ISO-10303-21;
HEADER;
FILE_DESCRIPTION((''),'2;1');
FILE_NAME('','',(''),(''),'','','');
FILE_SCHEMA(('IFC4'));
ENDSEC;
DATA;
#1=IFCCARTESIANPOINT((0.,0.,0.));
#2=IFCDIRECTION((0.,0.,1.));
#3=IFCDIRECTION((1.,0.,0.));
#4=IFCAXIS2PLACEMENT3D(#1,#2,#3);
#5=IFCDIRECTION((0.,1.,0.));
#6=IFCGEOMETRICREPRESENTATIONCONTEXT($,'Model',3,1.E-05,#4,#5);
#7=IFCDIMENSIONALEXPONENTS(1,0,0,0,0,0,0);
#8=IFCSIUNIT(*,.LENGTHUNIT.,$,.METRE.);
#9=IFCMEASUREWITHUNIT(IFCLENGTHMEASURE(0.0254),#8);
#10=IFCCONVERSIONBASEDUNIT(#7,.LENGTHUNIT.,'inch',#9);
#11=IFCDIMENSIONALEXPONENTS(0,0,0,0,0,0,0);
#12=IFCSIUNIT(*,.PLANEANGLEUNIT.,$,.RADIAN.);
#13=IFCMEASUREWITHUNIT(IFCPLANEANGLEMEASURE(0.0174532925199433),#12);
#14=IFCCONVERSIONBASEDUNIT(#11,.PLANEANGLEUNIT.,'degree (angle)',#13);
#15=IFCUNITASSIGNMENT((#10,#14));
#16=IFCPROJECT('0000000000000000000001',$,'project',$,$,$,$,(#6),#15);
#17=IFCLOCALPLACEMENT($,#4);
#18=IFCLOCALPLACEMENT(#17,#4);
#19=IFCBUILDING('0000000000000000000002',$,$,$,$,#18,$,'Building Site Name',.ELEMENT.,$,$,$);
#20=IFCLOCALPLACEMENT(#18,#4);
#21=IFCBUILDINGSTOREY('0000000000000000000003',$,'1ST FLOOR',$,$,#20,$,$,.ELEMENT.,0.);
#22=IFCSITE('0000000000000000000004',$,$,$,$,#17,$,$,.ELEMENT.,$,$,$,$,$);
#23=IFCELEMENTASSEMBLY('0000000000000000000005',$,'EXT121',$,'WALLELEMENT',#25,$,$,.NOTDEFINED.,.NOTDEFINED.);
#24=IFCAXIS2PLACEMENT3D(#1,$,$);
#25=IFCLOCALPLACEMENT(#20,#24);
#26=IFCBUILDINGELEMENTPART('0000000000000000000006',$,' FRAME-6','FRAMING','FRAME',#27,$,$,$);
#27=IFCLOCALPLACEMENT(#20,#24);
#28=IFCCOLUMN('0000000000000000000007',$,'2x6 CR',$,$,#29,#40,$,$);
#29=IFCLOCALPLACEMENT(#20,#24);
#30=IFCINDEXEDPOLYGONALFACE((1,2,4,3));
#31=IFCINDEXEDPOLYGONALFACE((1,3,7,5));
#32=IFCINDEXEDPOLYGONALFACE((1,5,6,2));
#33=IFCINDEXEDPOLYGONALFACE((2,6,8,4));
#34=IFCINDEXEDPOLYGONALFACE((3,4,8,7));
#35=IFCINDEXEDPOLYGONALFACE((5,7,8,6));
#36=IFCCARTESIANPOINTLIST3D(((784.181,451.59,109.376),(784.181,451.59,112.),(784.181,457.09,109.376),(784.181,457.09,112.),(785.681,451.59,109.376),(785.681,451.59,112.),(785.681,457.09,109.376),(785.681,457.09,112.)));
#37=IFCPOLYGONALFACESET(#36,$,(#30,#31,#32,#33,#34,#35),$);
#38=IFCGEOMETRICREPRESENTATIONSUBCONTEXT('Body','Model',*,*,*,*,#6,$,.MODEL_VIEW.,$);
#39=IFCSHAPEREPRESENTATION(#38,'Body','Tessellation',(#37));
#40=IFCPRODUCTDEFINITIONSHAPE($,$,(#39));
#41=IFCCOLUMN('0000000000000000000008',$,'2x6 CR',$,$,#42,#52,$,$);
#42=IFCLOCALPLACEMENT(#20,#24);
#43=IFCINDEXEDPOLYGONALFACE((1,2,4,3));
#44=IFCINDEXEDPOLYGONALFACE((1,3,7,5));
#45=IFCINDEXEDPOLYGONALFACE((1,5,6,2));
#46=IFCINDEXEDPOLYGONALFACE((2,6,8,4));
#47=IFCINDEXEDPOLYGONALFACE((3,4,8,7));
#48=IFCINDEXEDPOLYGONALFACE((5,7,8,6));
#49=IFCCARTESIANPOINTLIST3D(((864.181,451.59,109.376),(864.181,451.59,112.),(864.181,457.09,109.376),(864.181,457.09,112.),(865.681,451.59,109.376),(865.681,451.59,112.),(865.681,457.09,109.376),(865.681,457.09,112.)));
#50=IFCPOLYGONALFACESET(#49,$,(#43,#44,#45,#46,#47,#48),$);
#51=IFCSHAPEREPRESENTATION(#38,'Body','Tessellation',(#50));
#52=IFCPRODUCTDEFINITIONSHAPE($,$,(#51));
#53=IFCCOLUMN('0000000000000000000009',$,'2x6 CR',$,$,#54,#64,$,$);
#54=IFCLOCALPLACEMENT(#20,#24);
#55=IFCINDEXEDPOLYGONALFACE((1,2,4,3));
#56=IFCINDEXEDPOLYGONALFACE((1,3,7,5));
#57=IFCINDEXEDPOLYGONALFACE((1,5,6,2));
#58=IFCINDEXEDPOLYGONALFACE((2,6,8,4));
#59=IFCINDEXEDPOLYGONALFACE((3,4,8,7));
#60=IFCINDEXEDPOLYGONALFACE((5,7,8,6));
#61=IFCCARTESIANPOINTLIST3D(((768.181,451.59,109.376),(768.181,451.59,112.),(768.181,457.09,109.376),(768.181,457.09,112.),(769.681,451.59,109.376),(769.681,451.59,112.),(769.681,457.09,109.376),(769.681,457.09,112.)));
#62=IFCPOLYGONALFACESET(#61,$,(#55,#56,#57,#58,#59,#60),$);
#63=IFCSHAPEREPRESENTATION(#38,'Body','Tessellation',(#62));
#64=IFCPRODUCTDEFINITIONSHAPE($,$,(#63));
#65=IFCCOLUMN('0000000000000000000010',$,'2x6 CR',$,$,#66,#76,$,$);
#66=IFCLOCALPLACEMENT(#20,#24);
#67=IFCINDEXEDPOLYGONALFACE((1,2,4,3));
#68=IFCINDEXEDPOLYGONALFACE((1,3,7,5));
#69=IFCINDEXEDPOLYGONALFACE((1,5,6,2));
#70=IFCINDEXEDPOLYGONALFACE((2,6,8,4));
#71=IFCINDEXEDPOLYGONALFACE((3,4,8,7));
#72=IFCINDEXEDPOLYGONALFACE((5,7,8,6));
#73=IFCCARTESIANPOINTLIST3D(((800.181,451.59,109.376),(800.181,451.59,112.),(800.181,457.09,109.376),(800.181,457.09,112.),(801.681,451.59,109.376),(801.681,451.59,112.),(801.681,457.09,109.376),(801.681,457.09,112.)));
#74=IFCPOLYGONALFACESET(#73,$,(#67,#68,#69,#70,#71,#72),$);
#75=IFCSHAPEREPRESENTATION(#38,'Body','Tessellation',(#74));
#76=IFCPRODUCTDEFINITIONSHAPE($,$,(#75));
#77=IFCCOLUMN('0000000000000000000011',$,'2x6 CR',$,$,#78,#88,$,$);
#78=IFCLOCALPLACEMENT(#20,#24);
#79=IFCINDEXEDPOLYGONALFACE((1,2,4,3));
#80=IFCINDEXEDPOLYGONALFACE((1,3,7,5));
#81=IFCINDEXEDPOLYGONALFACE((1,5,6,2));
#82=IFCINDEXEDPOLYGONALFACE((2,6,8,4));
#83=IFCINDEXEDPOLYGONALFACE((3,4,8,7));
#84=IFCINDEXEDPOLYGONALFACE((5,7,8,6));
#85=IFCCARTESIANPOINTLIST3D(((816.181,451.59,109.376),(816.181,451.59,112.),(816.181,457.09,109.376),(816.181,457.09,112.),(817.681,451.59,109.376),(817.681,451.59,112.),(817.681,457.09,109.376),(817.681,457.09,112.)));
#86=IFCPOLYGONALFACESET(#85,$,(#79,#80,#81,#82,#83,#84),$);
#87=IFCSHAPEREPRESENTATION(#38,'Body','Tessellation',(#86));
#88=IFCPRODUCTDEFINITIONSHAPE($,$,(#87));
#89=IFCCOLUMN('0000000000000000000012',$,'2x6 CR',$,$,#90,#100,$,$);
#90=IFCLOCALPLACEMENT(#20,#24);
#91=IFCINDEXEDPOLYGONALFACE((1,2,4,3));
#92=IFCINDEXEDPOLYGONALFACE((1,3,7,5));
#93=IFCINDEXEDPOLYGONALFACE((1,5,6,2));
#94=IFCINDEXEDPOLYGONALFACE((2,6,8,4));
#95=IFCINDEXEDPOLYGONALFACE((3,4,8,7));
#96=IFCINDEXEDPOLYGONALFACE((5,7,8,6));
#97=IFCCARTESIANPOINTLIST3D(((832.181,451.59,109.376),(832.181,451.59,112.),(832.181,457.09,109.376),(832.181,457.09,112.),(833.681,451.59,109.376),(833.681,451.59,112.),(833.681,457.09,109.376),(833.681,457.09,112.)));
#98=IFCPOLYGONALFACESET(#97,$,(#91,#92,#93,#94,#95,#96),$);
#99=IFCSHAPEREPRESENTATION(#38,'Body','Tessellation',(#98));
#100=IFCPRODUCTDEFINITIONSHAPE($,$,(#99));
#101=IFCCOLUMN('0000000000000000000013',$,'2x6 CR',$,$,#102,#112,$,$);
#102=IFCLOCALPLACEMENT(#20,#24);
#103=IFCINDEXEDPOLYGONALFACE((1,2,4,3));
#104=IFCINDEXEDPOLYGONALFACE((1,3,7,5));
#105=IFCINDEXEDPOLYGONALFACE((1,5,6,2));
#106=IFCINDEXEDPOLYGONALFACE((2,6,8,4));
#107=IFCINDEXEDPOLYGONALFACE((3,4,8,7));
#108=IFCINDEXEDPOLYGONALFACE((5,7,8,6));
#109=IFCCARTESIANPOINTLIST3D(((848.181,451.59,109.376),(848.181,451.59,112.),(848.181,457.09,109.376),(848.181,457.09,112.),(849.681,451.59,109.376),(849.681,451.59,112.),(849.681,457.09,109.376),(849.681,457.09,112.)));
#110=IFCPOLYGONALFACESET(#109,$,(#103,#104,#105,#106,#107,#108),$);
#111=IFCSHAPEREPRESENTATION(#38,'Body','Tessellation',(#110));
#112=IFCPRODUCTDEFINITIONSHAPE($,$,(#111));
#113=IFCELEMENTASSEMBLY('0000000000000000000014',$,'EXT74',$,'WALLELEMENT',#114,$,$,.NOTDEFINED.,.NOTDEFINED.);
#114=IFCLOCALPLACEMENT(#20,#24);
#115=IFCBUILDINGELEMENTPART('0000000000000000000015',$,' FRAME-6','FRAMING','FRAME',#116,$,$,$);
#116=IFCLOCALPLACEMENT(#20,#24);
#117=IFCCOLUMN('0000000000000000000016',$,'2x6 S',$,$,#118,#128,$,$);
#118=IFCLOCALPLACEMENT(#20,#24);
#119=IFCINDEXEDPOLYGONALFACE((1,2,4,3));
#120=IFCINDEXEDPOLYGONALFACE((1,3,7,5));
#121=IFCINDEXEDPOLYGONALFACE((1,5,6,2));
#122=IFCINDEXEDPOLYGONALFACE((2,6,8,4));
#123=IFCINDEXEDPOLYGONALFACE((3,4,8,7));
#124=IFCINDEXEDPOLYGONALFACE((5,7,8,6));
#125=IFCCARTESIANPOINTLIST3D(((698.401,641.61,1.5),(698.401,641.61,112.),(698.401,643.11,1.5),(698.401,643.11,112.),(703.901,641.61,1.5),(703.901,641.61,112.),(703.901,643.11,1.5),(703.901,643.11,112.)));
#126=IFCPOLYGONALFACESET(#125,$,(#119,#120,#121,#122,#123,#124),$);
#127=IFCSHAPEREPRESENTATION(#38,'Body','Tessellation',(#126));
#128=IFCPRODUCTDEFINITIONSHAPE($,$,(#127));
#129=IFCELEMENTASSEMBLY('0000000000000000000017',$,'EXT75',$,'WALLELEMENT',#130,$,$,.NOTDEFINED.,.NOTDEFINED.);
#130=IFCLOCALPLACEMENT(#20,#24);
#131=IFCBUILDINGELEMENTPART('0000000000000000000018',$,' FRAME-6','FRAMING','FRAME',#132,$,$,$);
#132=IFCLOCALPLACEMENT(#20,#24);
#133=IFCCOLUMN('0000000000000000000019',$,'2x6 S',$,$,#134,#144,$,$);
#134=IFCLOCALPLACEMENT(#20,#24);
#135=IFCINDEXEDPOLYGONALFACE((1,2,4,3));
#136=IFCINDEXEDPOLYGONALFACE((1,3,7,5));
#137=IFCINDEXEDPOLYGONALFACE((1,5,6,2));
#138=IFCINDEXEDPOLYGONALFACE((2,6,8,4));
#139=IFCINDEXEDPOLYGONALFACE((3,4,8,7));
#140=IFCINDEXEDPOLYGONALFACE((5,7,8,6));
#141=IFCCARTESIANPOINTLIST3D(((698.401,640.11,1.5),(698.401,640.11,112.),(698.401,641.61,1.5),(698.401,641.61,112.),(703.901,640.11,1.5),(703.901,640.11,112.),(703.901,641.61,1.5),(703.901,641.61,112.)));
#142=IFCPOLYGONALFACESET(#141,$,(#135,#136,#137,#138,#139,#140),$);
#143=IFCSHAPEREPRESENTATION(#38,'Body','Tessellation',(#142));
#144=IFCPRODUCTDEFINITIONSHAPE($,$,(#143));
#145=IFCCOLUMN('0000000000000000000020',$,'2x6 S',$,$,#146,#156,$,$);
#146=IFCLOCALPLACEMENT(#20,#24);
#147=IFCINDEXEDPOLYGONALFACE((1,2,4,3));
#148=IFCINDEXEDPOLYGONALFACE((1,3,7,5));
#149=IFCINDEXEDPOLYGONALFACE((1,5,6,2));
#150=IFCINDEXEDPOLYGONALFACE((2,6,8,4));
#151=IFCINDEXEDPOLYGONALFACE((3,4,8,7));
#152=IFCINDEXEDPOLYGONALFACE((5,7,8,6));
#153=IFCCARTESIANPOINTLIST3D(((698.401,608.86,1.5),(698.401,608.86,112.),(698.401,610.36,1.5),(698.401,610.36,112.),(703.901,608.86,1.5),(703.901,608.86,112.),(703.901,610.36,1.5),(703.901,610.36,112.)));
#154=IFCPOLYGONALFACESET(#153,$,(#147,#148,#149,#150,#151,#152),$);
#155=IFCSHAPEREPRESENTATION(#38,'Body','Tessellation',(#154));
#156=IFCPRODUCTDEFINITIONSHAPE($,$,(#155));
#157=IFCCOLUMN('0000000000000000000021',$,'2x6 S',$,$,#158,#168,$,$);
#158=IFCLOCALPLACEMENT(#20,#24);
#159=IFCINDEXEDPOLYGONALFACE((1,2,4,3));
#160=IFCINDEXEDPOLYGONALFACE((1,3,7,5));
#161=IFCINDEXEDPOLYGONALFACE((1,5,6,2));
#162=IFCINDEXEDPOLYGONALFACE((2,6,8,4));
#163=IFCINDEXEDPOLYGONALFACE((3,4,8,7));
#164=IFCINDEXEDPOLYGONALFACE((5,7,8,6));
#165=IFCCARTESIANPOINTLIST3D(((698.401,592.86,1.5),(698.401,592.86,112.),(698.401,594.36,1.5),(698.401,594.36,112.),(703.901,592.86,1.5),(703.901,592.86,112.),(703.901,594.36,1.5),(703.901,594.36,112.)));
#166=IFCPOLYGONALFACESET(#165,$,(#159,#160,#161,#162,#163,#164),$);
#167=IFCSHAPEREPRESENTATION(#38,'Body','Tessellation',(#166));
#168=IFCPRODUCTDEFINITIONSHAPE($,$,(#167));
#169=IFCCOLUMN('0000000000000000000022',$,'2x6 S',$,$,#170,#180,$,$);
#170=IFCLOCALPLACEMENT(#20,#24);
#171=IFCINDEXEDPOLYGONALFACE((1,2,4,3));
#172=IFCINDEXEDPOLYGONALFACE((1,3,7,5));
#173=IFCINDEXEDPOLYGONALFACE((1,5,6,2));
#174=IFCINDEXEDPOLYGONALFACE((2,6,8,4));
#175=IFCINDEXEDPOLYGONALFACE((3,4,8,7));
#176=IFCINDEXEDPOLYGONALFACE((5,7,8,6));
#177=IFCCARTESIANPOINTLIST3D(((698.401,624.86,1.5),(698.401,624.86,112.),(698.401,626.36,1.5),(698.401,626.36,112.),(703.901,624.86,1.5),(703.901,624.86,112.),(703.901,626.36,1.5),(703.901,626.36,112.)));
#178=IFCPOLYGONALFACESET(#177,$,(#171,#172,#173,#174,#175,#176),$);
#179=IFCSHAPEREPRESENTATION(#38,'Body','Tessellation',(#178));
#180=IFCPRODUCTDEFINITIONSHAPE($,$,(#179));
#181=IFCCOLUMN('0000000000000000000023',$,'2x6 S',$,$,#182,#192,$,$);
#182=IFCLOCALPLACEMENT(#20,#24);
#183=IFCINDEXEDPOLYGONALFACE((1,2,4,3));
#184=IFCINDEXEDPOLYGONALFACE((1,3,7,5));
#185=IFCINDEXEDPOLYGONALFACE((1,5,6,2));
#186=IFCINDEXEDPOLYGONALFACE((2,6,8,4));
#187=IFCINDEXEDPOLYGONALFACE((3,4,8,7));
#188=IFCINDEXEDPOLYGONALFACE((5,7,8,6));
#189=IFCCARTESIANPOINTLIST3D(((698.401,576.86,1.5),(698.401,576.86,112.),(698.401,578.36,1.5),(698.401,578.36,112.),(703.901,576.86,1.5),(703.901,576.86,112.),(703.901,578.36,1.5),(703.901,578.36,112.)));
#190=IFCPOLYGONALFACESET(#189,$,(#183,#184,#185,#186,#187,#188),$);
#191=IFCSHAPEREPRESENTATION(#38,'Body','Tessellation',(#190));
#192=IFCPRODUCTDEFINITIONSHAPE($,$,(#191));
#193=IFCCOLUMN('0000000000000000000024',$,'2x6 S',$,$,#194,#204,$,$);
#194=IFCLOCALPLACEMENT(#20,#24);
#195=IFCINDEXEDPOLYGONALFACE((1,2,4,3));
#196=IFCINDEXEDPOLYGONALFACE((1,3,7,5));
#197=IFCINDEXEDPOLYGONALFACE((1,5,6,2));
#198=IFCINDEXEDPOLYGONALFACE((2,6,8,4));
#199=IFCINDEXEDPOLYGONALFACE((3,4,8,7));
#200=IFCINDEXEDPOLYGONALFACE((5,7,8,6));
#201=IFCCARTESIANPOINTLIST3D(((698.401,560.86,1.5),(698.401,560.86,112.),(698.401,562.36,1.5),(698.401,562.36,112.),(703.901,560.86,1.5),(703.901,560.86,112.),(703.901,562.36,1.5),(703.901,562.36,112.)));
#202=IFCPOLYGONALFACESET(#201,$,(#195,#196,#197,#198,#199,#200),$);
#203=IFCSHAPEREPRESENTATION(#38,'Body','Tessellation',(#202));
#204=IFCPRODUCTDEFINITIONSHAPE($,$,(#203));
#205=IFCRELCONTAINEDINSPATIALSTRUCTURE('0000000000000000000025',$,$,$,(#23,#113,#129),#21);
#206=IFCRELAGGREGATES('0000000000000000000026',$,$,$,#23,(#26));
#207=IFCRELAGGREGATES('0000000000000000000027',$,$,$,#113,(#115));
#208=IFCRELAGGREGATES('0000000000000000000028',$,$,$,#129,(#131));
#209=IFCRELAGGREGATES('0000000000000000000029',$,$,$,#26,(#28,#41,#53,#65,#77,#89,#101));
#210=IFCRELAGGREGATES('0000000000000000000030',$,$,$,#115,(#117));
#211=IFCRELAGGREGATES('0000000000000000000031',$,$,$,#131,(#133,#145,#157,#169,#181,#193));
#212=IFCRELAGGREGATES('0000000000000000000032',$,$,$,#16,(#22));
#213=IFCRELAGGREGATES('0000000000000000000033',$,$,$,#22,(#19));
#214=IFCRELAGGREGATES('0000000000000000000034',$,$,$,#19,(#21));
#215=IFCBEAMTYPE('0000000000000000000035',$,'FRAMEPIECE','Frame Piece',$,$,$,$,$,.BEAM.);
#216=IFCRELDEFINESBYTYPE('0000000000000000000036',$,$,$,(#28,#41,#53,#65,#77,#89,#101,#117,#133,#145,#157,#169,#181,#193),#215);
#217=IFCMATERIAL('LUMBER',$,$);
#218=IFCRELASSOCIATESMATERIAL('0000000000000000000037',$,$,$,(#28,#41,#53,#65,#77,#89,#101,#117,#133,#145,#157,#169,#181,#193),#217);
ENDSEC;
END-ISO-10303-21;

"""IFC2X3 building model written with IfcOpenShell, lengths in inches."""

from ifc_helpers import new_model, entity, si_unit, converted_unit, direction, frame, frame_2d, origin_with_axes, place, context, subcontext, project, spatial, rectangle, extrude, material, type_object, element, aggregate, save


model = new_model("IFC2X3")

# Units and contexts
model_context = context("Model", 3, precision=1e-05, world=origin_with_axes(), true_north=direction((0.0, 1.0, 0.0)))
body_context = subcontext(model_context, "Body", "Model", "MODEL_VIEW")
ifc_project = project(units=[converted_unit("LENGTHUNIT", "inch", entity("IfcLengthMeasure", 0.0254), si_unit("LENGTHUNIT", "METRE"), dimensions=[1, 0, 0, 0, 0, 0, 0]), converted_unit("PLANEANGLEUNIT", "degree (angle)", entity("IfcPlaneAngleMeasure", 0.0174532925199433), si_unit("PLANEANGLEUNIT", "RADIAN"), dimensions=[0, 0, 0, 0, 0, 0, 0])], contexts=[model_context])

# Site, building, storey
site_placement = place(None, origin_with_axes())
site = spatial("IfcSite", under=ifc_project, at=site_placement, CompositionType="ELEMENT")
building_placement = place(site_placement, origin_with_axes())
building = spatial("IfcBuilding", under=site, at=building_placement, LongName="Building Site Name", CompositionType="ELEMENT")
storey_placement = place(building_placement, origin_with_axes())
storey = spatial("IfcBuildingStorey", under=building, at=storey_placement, Name="1ST FLOOR", CompositionType="ELEMENT", Elevation=0.0)

# Element assembly, building element part, columns
assembly_1_placement = place(storey_placement, origin_with_axes())
assembly_1 = element("IfcElementAssembly", 1, at=assembly_1_placement, inside=storey, Name="EXT121", ObjectType="WALLELEMENT", AssemblyPlace="NOTDEFINED", PredefinedType="NOTDEFINED")
building_element_part_1 = element("IfcBuildingElementPart", 2, Name=" FRAME-6", Description="FRAMING", ObjectType="FRAME")
aggregate(assembly_1, [building_element_part_1])
ifc_material_1 = material(Name="LUMBER")
beam_type = type_object("IfcBeamType", Name="FRAMEPIECE", Description="Frame Piece", PredefinedType="BEAM")
column_1_placement = place(assembly_1_placement, frame((784.931, 454.34, 112.0), z_axis=(0.0, 0.0, -1.0), x_axis=(-1.0, 0.0, 0.0)))
column_1 = element("IfcColumn", 3, at=column_1_placement, type_object=beam_type, material=ifc_material_1, Name="2x6 CR", context=body_context, shape_type="SweptSolid", body=[
    extrude(rectangle(XDim=1.5, YDim=5.5, at=frame_2d((0.0, 0.0), x_axis=(-1.0, 0.0))), origin_with_axes(), (0.0, 0.0, 1.0), 2.624),
])
column_2_placement = place(assembly_1_placement, frame((864.931, 454.34, 112.0), z_axis=(0.0, 0.0, -1.0), x_axis=(-1.0, 0.0, 0.0)))
column_2 = element("IfcColumn", 4, at=column_2_placement, type_object=beam_type, material=ifc_material_1, Name="2x6 CR", context=body_context, shape_type="SweptSolid", body=[
    extrude(rectangle(XDim=1.5, YDim=5.5, at=frame_2d((0.0, 0.0), x_axis=(-1.0, 0.0))), origin_with_axes(), (0.0, 0.0, 1.0), 2.624),
])
column_3_placement = place(assembly_1_placement, frame((768.931, 454.34, 112.0), z_axis=(0.0, 0.0, -1.0), x_axis=(-1.0, 0.0, 0.0)))
column_3 = element("IfcColumn", 5, at=column_3_placement, type_object=beam_type, material=ifc_material_1, Name="2x6 CR", context=body_context, shape_type="SweptSolid", body=[
    extrude(rectangle(XDim=1.5, YDim=5.5, at=frame_2d((0.0, 0.0), x_axis=(-1.0, 0.0))), origin_with_axes(), (0.0, 0.0, 1.0), 2.624),
])
column_4_placement = place(assembly_1_placement, frame((800.931, 454.34, 112.0), z_axis=(0.0, 0.0, -1.0), x_axis=(-1.0, 0.0, 0.0)))
column_4 = element("IfcColumn", 6, at=column_4_placement, type_object=beam_type, material=ifc_material_1, Name="2x6 CR", context=body_context, shape_type="SweptSolid", body=[
    extrude(rectangle(XDim=1.5, YDim=5.5, at=frame_2d((0.0, 0.0), x_axis=(-1.0, 0.0))), origin_with_axes(), (0.0, 0.0, 1.0), 2.624),
])
column_5_placement = place(assembly_1_placement, frame((816.931, 454.34, 112.0), z_axis=(0.0, 0.0, -1.0), x_axis=(-1.0, 0.0, 0.0)))
column_5 = element("IfcColumn", 7, at=column_5_placement, type_object=beam_type, material=ifc_material_1, Name="2x6 CR", context=body_context, shape_type="SweptSolid", body=[
    extrude(rectangle(XDim=1.5, YDim=5.5, at=frame_2d((0.0, 0.0), x_axis=(-1.0, 0.0))), origin_with_axes(), (0.0, 0.0, 1.0), 2.624),
])
column_6_placement = place(assembly_1_placement, frame((832.931, 454.34, 112.0), z_axis=(0.0, 0.0, -1.0), x_axis=(-1.0, 0.0, 0.0)))
column_6 = element("IfcColumn", 8, at=column_6_placement, type_object=beam_type, material=ifc_material_1, Name="2x6 CR", context=body_context, shape_type="SweptSolid", body=[
    extrude(rectangle(XDim=1.5, YDim=5.5, at=frame_2d((0.0, 0.0), x_axis=(-1.0, 0.0))), origin_with_axes(), (0.0, 0.0, 1.0), 2.624),
])
column_7_placement = place(assembly_1_placement, frame((848.931, 454.34, 112.0), z_axis=(0.0, 0.0, -1.0), x_axis=(-1.0, 0.0, 0.0)))
column_7 = element("IfcColumn", 9, at=column_7_placement, type_object=beam_type, material=ifc_material_1, Name="2x6 CR", context=body_context, shape_type="SweptSolid", body=[
    extrude(rectangle(XDim=1.5, YDim=5.5, at=frame_2d((0.0, 0.0), x_axis=(-1.0, 0.0))), origin_with_axes(), (0.0, 0.0, 1.0), 2.624),
])

# Element assembly, building element part, column
assembly_2_placement = place(storey_placement, origin_with_axes())
assembly_2 = element("IfcElementAssembly", 10, at=assembly_2_placement, inside=storey, Name="EXT74", ObjectType="WALLELEMENT", AssemblyPlace="NOTDEFINED", PredefinedType="NOTDEFINED")
building_element_part_2 = element("IfcBuildingElementPart", 11, Name=" FRAME-6", Description="FRAMING", ObjectType="FRAME")
aggregate(assembly_2, [building_element_part_2])
column_8_placement = place(assembly_2_placement, frame((701.151, 642.36, 1.5), z_axis=(0.0, 0.0, 1.0), x_axis=(0.0, 1.0, 0.0)))
column_8 = element("IfcColumn", 12, at=column_8_placement, type_object=beam_type, material=ifc_material_1, Name="2x6 S", context=body_context, shape_type="SweptSolid", body=[
    extrude(rectangle(XDim=1.5, YDim=5.5, at=frame_2d((0.0, 0.0), x_axis=(-1.0, 0.0))), frame((0.0, 0.0, 0.0), z_axis=(0.0, 0.0, 1.0), x_axis=(1.0, 0.0, 0.0)), (0.0, 0.0, 1.0), 110.5),
])

# Element assembly, building element part, columns
assembly_3_placement = place(storey_placement, origin_with_axes())
assembly_3 = element("IfcElementAssembly", 13, at=assembly_3_placement, inside=storey, Name="EXT75", ObjectType="WALLELEMENT", AssemblyPlace="NOTDEFINED", PredefinedType="NOTDEFINED")
building_element_part_3 = element("IfcBuildingElementPart", 14, Name=" FRAME-6", Description="FRAMING", ObjectType="FRAME")
aggregate(assembly_3, [building_element_part_3])
column_9_placement = place(assembly_3_placement, frame((701.151, 640.86, 112.0), z_axis=(0.0, 0.0, -1.0), x_axis=(0.0, -1.0, 0.0)))
column_9 = element("IfcColumn", 15, at=column_9_placement, type_object=beam_type, material=ifc_material_1, Name="2x6 S", context=body_context, shape_type="SweptSolid", body=[
    extrude(rectangle(XDim=1.5, YDim=5.5, at=frame_2d((0.0, 0.0), x_axis=(-1.0, 0.0))), origin_with_axes(), (0.0, 0.0, 1.0), 110.5),
])
column_10_placement = place(assembly_3_placement, frame((701.151, 609.61, 112.0), z_axis=(0.0, 0.0, -1.0), x_axis=(0.0, -1.0, 0.0)))
column_10 = element("IfcColumn", 16, at=column_10_placement, type_object=beam_type, material=ifc_material_1, Name="2x6 S", context=body_context, shape_type="SweptSolid", body=[
    extrude(rectangle(XDim=1.5, YDim=5.5, at=frame_2d((0.0, 0.0), x_axis=(-1.0, 0.0))), origin_with_axes(), (0.0, 0.0, 1.0), 110.5),
])
column_11_placement = place(assembly_3_placement, frame((701.151, 593.61, 112.0), z_axis=(0.0, 0.0, -1.0), x_axis=(0.0, -1.0, 0.0)))
column_11 = element("IfcColumn", 17, at=column_11_placement, type_object=beam_type, material=ifc_material_1, Name="2x6 S", context=body_context, shape_type="SweptSolid", body=[
    extrude(rectangle(XDim=1.5, YDim=5.5, at=frame_2d((0.0, 0.0), x_axis=(-1.0, 0.0))), origin_with_axes(), (0.0, 0.0, 1.0), 110.5),
])
column_12_placement = place(assembly_3_placement, frame((701.151, 625.61, 112.0), z_axis=(0.0, 0.0, -1.0), x_axis=(0.0, -1.0, 0.0)))
column_12 = element("IfcColumn", 18, at=column_12_placement, type_object=beam_type, material=ifc_material_1, Name="2x6 S", context=body_context, shape_type="SweptSolid", body=[
    extrude(rectangle(XDim=1.5, YDim=5.5, at=frame_2d((0.0, 0.0), x_axis=(-1.0, 0.0))), origin_with_axes(), (0.0, 0.0, 1.0), 110.5),
])
column_13_placement = place(assembly_3_placement, frame((701.151, 577.61, 112.0), z_axis=(0.0, 0.0, -1.0), x_axis=(0.0, -1.0, 0.0)))
column_13 = element("IfcColumn", 19, at=column_13_placement, type_object=beam_type, material=ifc_material_1, Name="2x6 S", context=body_context, shape_type="SweptSolid", body=[
    extrude(rectangle(XDim=1.5, YDim=5.5, at=frame_2d((0.0, 0.0), x_axis=(-1.0, 0.0))), origin_with_axes(), (0.0, 0.0, 1.0), 110.5),
])
column_14_placement = place(assembly_3_placement, frame((701.151, 561.61, 112.0), z_axis=(0.0, 0.0, -1.0), x_axis=(0.0, -1.0, 0.0)))
column_14 = element("IfcColumn", 20, at=column_14_placement, type_object=beam_type, material=ifc_material_1, Name="2x6 S", context=body_context, shape_type="SweptSolid", body=[
    extrude(rectangle(XDim=1.5, YDim=5.5, at=frame_2d((0.0, 0.0), x_axis=(-1.0, 0.0))), origin_with_axes(), (0.0, 0.0, 1.0), 110.5),
])

aggregate(building_element_part_1, [column_1, column_2, column_3, column_4, column_5, column_6, column_7])
aggregate(building_element_part_2, [column_8])
aggregate(building_element_part_3, [column_9, column_10, column_11, column_12, column_13, column_14])

save(model, "model.ifc")
